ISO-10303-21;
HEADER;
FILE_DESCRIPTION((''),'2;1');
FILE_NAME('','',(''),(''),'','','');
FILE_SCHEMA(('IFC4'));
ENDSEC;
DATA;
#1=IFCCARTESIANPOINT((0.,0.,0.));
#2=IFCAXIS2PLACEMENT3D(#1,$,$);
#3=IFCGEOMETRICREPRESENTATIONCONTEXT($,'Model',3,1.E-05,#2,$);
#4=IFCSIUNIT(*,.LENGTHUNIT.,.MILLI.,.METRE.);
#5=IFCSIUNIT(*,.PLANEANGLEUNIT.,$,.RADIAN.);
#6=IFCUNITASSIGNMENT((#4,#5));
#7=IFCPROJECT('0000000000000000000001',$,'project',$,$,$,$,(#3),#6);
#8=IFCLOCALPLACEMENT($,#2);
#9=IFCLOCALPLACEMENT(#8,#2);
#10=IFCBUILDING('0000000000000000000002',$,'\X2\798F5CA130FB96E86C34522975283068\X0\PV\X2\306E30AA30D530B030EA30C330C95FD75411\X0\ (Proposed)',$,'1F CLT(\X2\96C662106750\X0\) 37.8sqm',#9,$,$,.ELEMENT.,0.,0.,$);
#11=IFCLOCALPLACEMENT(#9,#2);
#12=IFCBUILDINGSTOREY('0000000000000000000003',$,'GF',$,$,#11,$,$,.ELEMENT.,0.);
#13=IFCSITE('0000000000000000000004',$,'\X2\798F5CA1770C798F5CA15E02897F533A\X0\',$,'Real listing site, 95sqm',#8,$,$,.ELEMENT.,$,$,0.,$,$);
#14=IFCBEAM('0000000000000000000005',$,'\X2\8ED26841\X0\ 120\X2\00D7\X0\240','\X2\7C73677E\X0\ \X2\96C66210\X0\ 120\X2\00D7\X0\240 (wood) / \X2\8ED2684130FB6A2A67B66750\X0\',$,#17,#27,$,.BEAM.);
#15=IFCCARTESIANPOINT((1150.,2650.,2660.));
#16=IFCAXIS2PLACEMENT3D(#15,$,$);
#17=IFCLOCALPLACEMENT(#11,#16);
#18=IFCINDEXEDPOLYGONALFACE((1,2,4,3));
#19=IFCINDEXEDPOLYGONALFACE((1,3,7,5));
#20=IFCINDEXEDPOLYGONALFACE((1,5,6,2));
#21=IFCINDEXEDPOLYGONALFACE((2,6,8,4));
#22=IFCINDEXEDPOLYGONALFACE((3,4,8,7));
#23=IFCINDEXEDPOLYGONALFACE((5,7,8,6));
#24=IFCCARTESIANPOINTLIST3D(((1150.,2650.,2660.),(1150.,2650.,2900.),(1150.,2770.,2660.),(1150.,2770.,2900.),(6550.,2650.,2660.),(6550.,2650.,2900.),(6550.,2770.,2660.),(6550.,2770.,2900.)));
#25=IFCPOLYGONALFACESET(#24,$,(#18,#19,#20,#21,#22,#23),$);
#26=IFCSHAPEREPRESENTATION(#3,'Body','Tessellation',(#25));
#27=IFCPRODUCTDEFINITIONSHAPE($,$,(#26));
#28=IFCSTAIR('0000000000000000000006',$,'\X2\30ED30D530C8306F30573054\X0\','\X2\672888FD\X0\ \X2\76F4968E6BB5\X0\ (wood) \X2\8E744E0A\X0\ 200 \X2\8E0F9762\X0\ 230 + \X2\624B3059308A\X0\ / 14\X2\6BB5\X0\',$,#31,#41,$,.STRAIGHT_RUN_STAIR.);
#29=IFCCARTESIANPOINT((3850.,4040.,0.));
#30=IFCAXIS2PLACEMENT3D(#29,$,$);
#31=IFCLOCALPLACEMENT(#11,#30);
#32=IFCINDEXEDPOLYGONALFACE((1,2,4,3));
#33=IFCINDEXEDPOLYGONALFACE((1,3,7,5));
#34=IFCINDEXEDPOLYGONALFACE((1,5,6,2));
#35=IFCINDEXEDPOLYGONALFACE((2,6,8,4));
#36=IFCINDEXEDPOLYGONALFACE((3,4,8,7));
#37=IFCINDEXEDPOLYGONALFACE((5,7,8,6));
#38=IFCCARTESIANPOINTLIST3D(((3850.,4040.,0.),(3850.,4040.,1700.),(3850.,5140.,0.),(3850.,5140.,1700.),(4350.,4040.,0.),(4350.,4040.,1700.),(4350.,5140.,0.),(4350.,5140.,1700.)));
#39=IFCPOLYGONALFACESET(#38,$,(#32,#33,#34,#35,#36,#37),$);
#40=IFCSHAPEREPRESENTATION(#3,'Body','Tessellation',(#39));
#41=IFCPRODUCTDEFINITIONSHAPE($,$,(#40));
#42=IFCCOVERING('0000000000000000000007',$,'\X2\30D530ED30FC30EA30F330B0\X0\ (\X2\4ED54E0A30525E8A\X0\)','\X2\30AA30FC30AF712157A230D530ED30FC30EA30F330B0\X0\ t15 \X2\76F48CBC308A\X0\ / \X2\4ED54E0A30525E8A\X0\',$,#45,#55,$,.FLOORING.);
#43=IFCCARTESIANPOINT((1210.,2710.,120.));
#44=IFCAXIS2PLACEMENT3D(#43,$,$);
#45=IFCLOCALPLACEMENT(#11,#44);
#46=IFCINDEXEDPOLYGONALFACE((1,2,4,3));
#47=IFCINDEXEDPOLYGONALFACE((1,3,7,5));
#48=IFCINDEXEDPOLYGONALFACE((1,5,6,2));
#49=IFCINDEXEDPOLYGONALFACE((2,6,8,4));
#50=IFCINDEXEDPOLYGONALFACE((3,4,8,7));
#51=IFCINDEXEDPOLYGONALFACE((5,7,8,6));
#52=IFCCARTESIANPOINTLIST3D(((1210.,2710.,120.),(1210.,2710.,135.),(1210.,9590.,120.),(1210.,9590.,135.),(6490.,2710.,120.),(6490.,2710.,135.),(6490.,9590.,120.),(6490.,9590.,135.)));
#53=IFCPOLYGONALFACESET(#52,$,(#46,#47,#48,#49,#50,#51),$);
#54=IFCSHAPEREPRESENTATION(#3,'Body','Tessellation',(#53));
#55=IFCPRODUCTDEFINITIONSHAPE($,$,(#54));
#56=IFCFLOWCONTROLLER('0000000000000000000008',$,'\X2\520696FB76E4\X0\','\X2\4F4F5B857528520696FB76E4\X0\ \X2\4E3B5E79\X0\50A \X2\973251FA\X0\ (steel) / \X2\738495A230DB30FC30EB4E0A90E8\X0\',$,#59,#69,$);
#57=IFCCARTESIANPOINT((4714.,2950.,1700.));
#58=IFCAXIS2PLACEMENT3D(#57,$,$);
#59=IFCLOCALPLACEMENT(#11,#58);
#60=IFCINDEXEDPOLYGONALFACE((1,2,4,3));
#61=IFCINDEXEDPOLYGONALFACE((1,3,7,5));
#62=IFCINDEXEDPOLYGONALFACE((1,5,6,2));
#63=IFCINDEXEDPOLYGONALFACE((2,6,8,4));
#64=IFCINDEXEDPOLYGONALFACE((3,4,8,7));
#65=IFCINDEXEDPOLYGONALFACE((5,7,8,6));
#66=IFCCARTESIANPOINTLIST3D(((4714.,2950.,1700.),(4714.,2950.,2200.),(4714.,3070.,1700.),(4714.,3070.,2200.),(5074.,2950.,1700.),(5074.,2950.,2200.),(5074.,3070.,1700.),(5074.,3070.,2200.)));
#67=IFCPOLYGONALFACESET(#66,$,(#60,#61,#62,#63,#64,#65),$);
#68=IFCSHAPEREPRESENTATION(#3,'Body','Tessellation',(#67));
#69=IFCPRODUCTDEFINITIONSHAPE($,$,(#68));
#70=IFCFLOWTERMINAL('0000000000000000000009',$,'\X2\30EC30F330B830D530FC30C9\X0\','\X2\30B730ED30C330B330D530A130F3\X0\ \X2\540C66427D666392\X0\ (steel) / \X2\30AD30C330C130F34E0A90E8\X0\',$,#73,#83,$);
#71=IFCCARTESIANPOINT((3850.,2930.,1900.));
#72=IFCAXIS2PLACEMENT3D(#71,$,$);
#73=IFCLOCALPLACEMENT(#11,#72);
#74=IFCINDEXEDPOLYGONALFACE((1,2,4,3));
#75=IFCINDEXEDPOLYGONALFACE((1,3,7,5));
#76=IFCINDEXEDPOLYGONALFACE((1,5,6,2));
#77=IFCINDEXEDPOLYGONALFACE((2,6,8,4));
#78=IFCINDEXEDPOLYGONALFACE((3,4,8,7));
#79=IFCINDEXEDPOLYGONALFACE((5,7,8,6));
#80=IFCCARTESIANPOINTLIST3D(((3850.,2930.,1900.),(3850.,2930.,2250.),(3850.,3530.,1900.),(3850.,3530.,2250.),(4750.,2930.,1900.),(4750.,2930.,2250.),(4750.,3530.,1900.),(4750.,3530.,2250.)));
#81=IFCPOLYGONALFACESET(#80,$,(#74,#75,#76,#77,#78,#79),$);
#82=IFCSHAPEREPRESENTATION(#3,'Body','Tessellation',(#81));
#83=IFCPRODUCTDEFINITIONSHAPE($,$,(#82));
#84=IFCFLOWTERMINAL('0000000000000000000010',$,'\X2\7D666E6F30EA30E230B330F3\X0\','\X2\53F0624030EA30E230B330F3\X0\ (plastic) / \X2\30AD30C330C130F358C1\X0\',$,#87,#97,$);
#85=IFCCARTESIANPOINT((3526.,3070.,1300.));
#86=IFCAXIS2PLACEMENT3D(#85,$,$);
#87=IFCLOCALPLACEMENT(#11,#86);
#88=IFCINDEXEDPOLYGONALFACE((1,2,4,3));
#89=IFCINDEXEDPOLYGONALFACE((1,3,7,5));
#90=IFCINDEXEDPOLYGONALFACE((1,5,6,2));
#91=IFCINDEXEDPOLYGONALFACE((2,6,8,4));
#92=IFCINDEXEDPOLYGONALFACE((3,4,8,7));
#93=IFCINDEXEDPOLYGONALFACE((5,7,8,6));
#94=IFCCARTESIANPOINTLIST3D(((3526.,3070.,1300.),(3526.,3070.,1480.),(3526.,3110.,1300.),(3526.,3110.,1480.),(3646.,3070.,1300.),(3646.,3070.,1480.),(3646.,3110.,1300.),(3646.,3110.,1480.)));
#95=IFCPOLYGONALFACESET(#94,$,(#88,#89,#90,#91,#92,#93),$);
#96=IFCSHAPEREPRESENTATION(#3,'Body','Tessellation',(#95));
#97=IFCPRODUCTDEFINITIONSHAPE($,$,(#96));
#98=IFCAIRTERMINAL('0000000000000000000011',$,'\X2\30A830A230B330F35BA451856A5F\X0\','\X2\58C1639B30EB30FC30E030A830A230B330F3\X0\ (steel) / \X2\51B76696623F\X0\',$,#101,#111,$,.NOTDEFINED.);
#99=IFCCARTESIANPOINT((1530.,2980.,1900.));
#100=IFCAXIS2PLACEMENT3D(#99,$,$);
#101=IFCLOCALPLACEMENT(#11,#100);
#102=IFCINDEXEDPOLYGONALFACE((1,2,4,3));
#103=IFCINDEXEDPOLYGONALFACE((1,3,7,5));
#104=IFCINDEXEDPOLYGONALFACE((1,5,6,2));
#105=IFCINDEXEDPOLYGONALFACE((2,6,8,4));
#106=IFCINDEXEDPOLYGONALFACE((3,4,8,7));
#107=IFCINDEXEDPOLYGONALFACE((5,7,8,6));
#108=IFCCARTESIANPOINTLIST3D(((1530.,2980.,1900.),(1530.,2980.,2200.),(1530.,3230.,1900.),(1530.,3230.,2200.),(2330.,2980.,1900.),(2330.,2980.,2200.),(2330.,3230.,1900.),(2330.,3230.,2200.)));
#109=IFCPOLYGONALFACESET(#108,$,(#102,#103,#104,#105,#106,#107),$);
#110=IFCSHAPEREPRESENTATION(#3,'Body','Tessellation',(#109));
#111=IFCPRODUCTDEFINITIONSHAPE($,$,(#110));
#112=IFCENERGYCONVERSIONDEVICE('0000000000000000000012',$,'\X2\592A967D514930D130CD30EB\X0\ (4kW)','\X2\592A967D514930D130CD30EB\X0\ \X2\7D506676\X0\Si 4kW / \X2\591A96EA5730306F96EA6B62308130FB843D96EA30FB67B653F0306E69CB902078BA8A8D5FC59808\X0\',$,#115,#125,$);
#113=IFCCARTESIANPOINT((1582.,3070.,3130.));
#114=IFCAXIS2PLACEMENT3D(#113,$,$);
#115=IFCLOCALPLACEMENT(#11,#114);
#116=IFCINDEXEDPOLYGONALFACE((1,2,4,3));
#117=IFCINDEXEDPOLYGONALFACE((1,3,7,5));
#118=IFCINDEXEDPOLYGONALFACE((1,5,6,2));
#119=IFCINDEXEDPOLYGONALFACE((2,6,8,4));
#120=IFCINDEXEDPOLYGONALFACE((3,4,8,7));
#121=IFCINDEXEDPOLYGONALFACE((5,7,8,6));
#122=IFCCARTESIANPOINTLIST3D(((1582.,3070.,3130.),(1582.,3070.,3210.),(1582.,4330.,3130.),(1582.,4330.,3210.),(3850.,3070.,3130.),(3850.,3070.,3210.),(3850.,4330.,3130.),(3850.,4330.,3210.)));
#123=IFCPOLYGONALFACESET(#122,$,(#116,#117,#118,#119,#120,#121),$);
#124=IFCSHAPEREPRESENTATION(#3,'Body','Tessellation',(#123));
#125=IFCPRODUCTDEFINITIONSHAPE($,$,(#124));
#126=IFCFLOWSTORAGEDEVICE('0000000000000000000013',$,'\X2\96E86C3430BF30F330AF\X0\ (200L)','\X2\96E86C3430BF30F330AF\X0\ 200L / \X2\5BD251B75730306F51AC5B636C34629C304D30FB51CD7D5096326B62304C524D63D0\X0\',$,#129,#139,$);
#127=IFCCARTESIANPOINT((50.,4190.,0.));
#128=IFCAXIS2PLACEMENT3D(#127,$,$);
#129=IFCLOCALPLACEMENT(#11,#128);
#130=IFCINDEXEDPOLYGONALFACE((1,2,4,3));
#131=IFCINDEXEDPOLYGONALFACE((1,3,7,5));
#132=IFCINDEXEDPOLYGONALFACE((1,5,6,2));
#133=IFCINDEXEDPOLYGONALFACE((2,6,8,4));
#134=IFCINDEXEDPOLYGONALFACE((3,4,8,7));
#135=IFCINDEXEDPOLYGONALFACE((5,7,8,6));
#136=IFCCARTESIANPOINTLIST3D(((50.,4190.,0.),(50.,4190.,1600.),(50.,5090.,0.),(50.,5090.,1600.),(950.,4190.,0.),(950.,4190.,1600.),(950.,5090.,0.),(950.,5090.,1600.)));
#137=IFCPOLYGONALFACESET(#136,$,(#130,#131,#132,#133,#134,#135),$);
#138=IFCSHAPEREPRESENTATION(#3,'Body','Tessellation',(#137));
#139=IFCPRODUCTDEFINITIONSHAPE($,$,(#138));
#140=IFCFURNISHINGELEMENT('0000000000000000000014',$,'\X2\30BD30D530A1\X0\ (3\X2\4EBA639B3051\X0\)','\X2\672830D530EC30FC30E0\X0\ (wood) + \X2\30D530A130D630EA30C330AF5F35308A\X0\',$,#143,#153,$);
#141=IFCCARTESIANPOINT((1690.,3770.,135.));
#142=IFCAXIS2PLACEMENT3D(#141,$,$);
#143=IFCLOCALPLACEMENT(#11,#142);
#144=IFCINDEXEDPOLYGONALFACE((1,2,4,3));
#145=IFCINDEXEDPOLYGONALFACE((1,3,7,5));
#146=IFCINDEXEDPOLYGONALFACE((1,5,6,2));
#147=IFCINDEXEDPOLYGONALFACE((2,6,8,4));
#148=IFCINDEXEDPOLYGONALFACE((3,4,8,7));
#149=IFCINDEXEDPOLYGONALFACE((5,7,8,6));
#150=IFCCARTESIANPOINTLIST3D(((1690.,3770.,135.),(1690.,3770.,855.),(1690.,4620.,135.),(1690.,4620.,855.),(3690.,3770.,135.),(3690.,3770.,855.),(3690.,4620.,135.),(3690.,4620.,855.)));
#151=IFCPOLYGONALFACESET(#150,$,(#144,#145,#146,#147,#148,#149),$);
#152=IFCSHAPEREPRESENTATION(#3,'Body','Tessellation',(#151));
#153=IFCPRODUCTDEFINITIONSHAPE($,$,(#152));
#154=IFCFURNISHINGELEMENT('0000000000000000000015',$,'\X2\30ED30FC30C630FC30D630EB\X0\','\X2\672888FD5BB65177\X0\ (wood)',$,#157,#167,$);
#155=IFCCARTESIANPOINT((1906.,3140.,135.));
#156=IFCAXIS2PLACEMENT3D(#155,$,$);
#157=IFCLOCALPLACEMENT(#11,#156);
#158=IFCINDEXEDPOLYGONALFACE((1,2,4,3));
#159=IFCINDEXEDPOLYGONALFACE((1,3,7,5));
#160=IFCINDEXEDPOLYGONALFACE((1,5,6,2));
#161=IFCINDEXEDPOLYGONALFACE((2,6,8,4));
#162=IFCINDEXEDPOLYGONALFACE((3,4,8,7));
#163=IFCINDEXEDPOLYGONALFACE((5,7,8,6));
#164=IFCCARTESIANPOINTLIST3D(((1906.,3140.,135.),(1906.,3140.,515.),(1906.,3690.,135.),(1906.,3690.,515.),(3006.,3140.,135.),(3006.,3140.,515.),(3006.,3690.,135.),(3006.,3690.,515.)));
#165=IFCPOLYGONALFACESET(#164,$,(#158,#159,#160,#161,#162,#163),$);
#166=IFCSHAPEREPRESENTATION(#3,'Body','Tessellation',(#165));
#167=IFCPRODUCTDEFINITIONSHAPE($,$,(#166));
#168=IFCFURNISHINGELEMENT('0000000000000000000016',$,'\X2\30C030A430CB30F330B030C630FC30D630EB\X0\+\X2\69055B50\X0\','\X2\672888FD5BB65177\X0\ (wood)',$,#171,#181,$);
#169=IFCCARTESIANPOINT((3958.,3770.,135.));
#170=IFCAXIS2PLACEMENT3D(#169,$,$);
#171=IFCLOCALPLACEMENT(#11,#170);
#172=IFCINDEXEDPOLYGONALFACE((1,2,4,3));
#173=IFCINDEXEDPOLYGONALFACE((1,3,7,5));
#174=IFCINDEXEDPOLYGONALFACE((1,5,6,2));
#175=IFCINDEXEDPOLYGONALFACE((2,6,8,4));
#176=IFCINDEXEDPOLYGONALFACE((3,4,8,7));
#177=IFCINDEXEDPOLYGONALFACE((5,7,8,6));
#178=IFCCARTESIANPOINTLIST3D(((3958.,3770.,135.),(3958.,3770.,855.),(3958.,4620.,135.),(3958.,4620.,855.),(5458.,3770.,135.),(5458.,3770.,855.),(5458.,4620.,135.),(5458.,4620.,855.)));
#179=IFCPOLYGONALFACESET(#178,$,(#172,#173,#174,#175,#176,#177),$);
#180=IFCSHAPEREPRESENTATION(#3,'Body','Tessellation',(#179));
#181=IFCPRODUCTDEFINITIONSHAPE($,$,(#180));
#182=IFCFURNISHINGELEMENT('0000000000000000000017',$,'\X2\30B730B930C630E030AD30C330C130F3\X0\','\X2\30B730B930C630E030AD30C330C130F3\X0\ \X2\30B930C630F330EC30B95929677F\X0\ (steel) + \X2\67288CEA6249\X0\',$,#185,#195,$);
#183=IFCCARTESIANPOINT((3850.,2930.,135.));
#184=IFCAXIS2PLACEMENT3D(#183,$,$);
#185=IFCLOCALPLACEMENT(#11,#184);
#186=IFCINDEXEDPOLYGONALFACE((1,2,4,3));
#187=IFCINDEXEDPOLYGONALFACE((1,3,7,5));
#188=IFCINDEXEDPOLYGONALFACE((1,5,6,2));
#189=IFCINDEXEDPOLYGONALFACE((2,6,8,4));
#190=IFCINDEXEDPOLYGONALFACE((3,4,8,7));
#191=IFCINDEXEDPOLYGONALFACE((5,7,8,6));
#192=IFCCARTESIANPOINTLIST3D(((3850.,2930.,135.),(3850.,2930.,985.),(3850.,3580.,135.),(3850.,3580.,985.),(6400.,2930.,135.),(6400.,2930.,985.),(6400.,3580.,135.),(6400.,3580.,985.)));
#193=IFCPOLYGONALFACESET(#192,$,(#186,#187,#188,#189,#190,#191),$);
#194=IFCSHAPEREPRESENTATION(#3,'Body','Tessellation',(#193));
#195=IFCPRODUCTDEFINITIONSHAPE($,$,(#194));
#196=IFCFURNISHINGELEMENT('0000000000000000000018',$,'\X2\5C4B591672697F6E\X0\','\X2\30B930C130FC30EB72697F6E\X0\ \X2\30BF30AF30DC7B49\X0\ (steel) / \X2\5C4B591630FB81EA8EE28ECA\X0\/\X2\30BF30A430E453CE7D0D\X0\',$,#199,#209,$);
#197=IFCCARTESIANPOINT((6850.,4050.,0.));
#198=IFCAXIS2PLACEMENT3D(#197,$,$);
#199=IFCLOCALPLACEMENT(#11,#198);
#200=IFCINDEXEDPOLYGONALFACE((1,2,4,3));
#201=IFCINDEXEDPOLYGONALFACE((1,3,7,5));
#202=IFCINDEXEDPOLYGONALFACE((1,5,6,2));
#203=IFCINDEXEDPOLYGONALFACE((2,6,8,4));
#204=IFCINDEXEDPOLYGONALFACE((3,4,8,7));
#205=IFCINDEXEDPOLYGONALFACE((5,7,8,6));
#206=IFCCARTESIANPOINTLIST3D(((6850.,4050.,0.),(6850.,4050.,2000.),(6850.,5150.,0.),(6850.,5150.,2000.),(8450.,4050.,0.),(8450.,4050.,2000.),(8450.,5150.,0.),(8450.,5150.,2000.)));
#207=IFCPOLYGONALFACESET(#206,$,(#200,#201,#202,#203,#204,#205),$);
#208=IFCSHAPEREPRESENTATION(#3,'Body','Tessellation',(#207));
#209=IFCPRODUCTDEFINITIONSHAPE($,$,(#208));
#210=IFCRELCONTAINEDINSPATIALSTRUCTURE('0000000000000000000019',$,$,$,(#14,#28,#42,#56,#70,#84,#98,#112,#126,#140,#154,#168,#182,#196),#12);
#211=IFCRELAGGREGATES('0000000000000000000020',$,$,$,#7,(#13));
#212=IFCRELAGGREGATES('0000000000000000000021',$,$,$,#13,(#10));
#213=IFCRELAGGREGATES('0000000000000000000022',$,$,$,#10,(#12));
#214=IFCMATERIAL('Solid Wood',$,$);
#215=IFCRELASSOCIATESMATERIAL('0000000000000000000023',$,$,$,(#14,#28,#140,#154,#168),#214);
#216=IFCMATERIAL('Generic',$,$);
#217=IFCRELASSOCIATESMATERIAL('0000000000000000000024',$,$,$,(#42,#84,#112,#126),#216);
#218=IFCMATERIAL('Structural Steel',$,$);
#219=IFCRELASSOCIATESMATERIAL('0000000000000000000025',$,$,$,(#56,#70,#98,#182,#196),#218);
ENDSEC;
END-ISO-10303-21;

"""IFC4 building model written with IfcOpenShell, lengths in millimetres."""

from ifc_helpers import new_model, si_unit, frame, frame_2d, origin, place, context, project, spatial, rectangle, extrude, material, element, save


model = new_model("IFC4")

# Units and contexts
model_context = context("Model", 3, precision=1e-05, world=origin())
ifc_project = project(units=[si_unit("LENGTHUNIT", "METRE", prefix="MILLI"), si_unit("PLANEANGLEUNIT", "RADIAN")], contexts=[model_context])

# Site, building, storey
site_placement = place(None, origin())
site = spatial("IfcSite", under=ifc_project, at=site_placement, Name="福岡県福岡市西区", ObjectType="Real listing site, 95sqm", CompositionType="ELEMENT", RefElevation=0.0)
building_placement = place(site_placement, origin())
building = spatial("IfcBuilding", under=site, at=building_placement, Name="福岡・雨水利用とPVのオフグリッド志向 (Proposed)", ObjectType="1F CLT(集成材) 37.8sqm", CompositionType="ELEMENT", ElevationOfRefHeight=0.0, ElevationOfTerrain=0.0)
storey_placement = place(building_placement, origin())
storey = spatial("IfcBuildingStorey", under=building, at=storey_placement, Name="GF", CompositionType="ELEMENT", Elevation=0.0)

# Beam
ifc_material_1 = material(Name="Solid Wood")
beam_1_placement = place(storey_placement, frame((1150.0, 2650.0, 2660.0)))
element("IfcBeam", 1, at=beam_1_placement, inside=storey, material=ifc_material_1, Name="軒桁 120×240", Description="米松 集成 120×240 (wood) / 軒桁・横架材", PredefinedType="BEAM", context=model_context, shape_type="SweptSolid", body=[
    extrude(rectangle(XDim=5400.0, YDim=120.0, at=frame_2d((2700.0, 60.0))), frame((1150.0, 2650.0, 2660.0)), (0.0, 0.0, 1.0), 240.0),
])

# Stair
stair_placement = place(storey_placement, frame((3850.0, 4040.0, 0.0)))
element("IfcStair", 2, at=stair_placement, inside=storey, material=ifc_material_1, Name="ロフトはしご", Description="木製 直階段 (wood) 蹴上 200 踏面 230 + 手すり / 14段", PredefinedType="STRAIGHT_RUN_STAIR", context=model_context, shape_type="SweptSolid", body=[
    extrude(rectangle(XDim=500.0, YDim=1100.0, at=frame_2d((250.0, 550.0))), frame((3850.0, 4040.0, 0.0)), (0.0, 0.0, 1.0), 1700.0),
])

# Covering
ifc_material_2 = material(Name="Generic")
covering_placement = place(storey_placement, frame((1210.0, 2710.0, 120.0)))
element("IfcCovering", 3, at=covering_placement, inside=storey, material=ifc_material_2, Name="フローリング (仕上げ床)", Description="オーク無垢フローリング t15 直貼り / 仕上げ床", PredefinedType="FLOORING", context=model_context, shape_type="SweptSolid", body=[
    extrude(rectangle(XDim=5280.0, YDim=6880.0, at=frame_2d((2640.0, 3440.0))), frame((1210.0, 2710.0, 120.0)), (0.0, 0.0, 1.0), 15.0),
])

# Flow controller
ifc_material_3 = material(Name="Structural Steel")
flow_controller_placement = place(storey_placement, frame((4714.0, 2950.0, 1700.0)))
element("IfcFlowController", 4, at=flow_controller_placement, inside=storey, material=ifc_material_3, Name="分電盤", Description="住宅用分電盤 主幹50A 露出 (steel) / 玄関ホール上部", context=model_context, shape_type="SweptSolid", body=[
    extrude(rectangle(XDim=360.0, YDim=120.0, at=frame_2d((180.0, 60.0))), frame((4714.0, 2950.0, 1700.0)), (0.0, 0.0, 1.0), 500.0),
])

# Flow terminals
flow_terminal_1_placement = place(storey_placement, frame((3850.0, 2930.0, 1900.0)))
element("IfcFlowTerminal", 5, at=flow_terminal_1_placement, inside=storey, material=ifc_material_3, Name="レンジフード", Description="シロッコファン 同時給排 (steel) / キッチン上部", context=model_context, shape_type="SweptSolid", body=[
    extrude(rectangle(XDim=900.0, YDim=600.0, at=frame_2d((450.0, 300.0))), frame((3850.0, 2930.0, 1900.0)), (0.0, 0.0, 1.0), 350.0),
])
flow_terminal_2_placement = place(storey_placement, frame((3526.0, 3070.0, 1300.0)))
element("IfcFlowTerminal", 6, at=flow_terminal_2_placement, inside=storey, material=ifc_material_2, Name="給湯リモコン", Description="台所リモコン (plastic) / キッチン壁", context=model_context, shape_type="SweptSolid", body=[
    extrude(rectangle(XDim=120.0, YDim=40.0, at=frame_2d((60.0, 20.0))), frame((3526.0, 3070.0, 1300.0)), (0.0, 0.0, 1.0), 180.0),
])

# Air terminal
air_terminal_placement = place(storey_placement, frame((1530.0, 2980.0, 1900.0)))
element("IfcAirTerminal", 7, at=air_terminal_placement, inside=storey, material=ifc_material_3, Name="エアコン室内機", Description="壁掛ルームエアコン (steel) / 冷暖房", PredefinedType="NOTDEFINED", context=model_context, shape_type="SweptSolid", body=[
    extrude(rectangle(XDim=800.0, YDim=250.0, at=frame_2d((400.0, 125.0))), frame((1530.0, 2980.0, 1900.0)), (0.0, 0.0, 1.0), 300.0),
])

# Energy conversion device
energy_conversion_device_placement = place(storey_placement, frame((1582.0, 3070.0, 3130.0)))
element("IfcEnergyConversionDevice", 8, at=energy_conversion_device_placement, inside=storey, material=ifc_material_2, Name="太陽光パネル (4kW)", Description="太陽光パネル 結晶Si 4kW / 多雪地は雪止め・落雪・架台の構造確認必須", context=model_context, shape_type="SweptSolid", body=[
    extrude(rectangle(XDim=2268.0, YDim=1260.0, at=frame_2d((1134.0, 630.0))), frame((1582.0, 3070.0, 3130.0)), (0.0, 0.0, 1.0), 80.0),
])

# Flow storage device
flow_storage_device_placement = place(storey_placement, frame((50.0, 4190.0, 0.0)))
element("IfcFlowStorageDevice", 9, at=flow_storage_device_placement, inside=storey, material=ifc_material_2, Name="雨水タンク (200L)", Description="雨水タンク 200L / 寒冷地は冬季水抜き・凍結防止が前提", context=model_context, shape_type="SweptSolid", body=[
    extrude(rectangle(XDim=900.0, YDim=900.0, at=frame_2d((450.0, 450.0))), frame((50.0, 4190.0, 0.0)), (0.0, 0.0, 1.0), 1600.0),
])

# Furnishing elements
furnishing_1_placement = place(storey_placement, frame((1690.0, 3770.0, 135.0)))
element("IfcFurnishingElement", 10, at=furnishing_1_placement, inside=storey, material=ifc_material_1, Name="ソファ (3人掛け)", Description="木フレーム (wood) + ファブリック張り", context=model_context, shape_type="SweptSolid", body=[
    extrude(rectangle(XDim=2000.0, YDim=850.0, at=frame_2d((1000.0, 425.0))), frame((1690.0, 3770.0, 135.0)), (0.0, 0.0, 1.0), 720.0),
])
furnishing_2_placement = place(storey_placement, frame((1906.0, 3140.0, 135.0)))
element("IfcFurnishingElement", 11, at=furnishing_2_placement, inside=storey, material=ifc_material_1, Name="ローテーブル", Description="木製家具 (wood)", context=model_context, shape_type="SweptSolid", body=[
    extrude(rectangle(XDim=1100.0, YDim=550.0, at=frame_2d((550.0, 275.0))), frame((1906.0, 3140.0, 135.0)), (0.0, 0.0, 1.0), 380.0),
])
furnishing_3_placement = place(storey_placement, frame((3958.0, 3770.0, 135.0)))
element("IfcFurnishingElement", 12, at=furnishing_3_placement, inside=storey, material=ifc_material_1, Name="ダイニングテーブル+椅子", Description="木製家具 (wood)", context=model_context, shape_type="SweptSolid", body=[
    extrude(rectangle(XDim=1500.0, YDim=850.0, at=frame_2d((750.0, 425.0))), frame((3958.0, 3770.0, 135.0)), (0.0, 0.0, 1.0), 720.0),
])
furnishing_4_placement = place(storey_placement, frame((3850.0, 2930.0, 135.0)))
element("IfcFurnishingElement", 13, at=furnishing_4_placement, inside=storey, material=ifc_material_3, Name="システムキッチン", Description="システムキッチン ステンレス天板 (steel) + 木質扉", context=model_context, shape_type="SweptSolid", body=[
    extrude(rectangle(XDim=2550.0, YDim=650.0, at=frame_2d((1275.0, 325.0))), frame((3850.0, 2930.0, 135.0)), (0.0, 0.0, 1.0), 850.0),
])
furnishing_5_placement = place(storey_placement, frame((6850.0, 4050.0, 0.0)))
element("IfcFurnishingElement", 14, at=furnishing_5_placement, inside=storey, material=ifc_material_3, Name="屋外物置", Description="スチール物置 タクボ等 (steel) / 屋外・自転車/タイヤ収納", context=model_context, shape_type="SweptSolid", body=[
    extrude(rectangle(XDim=1600.0, YDim=1100.0, at=frame_2d((800.0, 550.0))), frame((6850.0, 4050.0, 0.0)), (0.0, 0.0, 1.0), 2000.0),
])

save(model, "model.ifc")
